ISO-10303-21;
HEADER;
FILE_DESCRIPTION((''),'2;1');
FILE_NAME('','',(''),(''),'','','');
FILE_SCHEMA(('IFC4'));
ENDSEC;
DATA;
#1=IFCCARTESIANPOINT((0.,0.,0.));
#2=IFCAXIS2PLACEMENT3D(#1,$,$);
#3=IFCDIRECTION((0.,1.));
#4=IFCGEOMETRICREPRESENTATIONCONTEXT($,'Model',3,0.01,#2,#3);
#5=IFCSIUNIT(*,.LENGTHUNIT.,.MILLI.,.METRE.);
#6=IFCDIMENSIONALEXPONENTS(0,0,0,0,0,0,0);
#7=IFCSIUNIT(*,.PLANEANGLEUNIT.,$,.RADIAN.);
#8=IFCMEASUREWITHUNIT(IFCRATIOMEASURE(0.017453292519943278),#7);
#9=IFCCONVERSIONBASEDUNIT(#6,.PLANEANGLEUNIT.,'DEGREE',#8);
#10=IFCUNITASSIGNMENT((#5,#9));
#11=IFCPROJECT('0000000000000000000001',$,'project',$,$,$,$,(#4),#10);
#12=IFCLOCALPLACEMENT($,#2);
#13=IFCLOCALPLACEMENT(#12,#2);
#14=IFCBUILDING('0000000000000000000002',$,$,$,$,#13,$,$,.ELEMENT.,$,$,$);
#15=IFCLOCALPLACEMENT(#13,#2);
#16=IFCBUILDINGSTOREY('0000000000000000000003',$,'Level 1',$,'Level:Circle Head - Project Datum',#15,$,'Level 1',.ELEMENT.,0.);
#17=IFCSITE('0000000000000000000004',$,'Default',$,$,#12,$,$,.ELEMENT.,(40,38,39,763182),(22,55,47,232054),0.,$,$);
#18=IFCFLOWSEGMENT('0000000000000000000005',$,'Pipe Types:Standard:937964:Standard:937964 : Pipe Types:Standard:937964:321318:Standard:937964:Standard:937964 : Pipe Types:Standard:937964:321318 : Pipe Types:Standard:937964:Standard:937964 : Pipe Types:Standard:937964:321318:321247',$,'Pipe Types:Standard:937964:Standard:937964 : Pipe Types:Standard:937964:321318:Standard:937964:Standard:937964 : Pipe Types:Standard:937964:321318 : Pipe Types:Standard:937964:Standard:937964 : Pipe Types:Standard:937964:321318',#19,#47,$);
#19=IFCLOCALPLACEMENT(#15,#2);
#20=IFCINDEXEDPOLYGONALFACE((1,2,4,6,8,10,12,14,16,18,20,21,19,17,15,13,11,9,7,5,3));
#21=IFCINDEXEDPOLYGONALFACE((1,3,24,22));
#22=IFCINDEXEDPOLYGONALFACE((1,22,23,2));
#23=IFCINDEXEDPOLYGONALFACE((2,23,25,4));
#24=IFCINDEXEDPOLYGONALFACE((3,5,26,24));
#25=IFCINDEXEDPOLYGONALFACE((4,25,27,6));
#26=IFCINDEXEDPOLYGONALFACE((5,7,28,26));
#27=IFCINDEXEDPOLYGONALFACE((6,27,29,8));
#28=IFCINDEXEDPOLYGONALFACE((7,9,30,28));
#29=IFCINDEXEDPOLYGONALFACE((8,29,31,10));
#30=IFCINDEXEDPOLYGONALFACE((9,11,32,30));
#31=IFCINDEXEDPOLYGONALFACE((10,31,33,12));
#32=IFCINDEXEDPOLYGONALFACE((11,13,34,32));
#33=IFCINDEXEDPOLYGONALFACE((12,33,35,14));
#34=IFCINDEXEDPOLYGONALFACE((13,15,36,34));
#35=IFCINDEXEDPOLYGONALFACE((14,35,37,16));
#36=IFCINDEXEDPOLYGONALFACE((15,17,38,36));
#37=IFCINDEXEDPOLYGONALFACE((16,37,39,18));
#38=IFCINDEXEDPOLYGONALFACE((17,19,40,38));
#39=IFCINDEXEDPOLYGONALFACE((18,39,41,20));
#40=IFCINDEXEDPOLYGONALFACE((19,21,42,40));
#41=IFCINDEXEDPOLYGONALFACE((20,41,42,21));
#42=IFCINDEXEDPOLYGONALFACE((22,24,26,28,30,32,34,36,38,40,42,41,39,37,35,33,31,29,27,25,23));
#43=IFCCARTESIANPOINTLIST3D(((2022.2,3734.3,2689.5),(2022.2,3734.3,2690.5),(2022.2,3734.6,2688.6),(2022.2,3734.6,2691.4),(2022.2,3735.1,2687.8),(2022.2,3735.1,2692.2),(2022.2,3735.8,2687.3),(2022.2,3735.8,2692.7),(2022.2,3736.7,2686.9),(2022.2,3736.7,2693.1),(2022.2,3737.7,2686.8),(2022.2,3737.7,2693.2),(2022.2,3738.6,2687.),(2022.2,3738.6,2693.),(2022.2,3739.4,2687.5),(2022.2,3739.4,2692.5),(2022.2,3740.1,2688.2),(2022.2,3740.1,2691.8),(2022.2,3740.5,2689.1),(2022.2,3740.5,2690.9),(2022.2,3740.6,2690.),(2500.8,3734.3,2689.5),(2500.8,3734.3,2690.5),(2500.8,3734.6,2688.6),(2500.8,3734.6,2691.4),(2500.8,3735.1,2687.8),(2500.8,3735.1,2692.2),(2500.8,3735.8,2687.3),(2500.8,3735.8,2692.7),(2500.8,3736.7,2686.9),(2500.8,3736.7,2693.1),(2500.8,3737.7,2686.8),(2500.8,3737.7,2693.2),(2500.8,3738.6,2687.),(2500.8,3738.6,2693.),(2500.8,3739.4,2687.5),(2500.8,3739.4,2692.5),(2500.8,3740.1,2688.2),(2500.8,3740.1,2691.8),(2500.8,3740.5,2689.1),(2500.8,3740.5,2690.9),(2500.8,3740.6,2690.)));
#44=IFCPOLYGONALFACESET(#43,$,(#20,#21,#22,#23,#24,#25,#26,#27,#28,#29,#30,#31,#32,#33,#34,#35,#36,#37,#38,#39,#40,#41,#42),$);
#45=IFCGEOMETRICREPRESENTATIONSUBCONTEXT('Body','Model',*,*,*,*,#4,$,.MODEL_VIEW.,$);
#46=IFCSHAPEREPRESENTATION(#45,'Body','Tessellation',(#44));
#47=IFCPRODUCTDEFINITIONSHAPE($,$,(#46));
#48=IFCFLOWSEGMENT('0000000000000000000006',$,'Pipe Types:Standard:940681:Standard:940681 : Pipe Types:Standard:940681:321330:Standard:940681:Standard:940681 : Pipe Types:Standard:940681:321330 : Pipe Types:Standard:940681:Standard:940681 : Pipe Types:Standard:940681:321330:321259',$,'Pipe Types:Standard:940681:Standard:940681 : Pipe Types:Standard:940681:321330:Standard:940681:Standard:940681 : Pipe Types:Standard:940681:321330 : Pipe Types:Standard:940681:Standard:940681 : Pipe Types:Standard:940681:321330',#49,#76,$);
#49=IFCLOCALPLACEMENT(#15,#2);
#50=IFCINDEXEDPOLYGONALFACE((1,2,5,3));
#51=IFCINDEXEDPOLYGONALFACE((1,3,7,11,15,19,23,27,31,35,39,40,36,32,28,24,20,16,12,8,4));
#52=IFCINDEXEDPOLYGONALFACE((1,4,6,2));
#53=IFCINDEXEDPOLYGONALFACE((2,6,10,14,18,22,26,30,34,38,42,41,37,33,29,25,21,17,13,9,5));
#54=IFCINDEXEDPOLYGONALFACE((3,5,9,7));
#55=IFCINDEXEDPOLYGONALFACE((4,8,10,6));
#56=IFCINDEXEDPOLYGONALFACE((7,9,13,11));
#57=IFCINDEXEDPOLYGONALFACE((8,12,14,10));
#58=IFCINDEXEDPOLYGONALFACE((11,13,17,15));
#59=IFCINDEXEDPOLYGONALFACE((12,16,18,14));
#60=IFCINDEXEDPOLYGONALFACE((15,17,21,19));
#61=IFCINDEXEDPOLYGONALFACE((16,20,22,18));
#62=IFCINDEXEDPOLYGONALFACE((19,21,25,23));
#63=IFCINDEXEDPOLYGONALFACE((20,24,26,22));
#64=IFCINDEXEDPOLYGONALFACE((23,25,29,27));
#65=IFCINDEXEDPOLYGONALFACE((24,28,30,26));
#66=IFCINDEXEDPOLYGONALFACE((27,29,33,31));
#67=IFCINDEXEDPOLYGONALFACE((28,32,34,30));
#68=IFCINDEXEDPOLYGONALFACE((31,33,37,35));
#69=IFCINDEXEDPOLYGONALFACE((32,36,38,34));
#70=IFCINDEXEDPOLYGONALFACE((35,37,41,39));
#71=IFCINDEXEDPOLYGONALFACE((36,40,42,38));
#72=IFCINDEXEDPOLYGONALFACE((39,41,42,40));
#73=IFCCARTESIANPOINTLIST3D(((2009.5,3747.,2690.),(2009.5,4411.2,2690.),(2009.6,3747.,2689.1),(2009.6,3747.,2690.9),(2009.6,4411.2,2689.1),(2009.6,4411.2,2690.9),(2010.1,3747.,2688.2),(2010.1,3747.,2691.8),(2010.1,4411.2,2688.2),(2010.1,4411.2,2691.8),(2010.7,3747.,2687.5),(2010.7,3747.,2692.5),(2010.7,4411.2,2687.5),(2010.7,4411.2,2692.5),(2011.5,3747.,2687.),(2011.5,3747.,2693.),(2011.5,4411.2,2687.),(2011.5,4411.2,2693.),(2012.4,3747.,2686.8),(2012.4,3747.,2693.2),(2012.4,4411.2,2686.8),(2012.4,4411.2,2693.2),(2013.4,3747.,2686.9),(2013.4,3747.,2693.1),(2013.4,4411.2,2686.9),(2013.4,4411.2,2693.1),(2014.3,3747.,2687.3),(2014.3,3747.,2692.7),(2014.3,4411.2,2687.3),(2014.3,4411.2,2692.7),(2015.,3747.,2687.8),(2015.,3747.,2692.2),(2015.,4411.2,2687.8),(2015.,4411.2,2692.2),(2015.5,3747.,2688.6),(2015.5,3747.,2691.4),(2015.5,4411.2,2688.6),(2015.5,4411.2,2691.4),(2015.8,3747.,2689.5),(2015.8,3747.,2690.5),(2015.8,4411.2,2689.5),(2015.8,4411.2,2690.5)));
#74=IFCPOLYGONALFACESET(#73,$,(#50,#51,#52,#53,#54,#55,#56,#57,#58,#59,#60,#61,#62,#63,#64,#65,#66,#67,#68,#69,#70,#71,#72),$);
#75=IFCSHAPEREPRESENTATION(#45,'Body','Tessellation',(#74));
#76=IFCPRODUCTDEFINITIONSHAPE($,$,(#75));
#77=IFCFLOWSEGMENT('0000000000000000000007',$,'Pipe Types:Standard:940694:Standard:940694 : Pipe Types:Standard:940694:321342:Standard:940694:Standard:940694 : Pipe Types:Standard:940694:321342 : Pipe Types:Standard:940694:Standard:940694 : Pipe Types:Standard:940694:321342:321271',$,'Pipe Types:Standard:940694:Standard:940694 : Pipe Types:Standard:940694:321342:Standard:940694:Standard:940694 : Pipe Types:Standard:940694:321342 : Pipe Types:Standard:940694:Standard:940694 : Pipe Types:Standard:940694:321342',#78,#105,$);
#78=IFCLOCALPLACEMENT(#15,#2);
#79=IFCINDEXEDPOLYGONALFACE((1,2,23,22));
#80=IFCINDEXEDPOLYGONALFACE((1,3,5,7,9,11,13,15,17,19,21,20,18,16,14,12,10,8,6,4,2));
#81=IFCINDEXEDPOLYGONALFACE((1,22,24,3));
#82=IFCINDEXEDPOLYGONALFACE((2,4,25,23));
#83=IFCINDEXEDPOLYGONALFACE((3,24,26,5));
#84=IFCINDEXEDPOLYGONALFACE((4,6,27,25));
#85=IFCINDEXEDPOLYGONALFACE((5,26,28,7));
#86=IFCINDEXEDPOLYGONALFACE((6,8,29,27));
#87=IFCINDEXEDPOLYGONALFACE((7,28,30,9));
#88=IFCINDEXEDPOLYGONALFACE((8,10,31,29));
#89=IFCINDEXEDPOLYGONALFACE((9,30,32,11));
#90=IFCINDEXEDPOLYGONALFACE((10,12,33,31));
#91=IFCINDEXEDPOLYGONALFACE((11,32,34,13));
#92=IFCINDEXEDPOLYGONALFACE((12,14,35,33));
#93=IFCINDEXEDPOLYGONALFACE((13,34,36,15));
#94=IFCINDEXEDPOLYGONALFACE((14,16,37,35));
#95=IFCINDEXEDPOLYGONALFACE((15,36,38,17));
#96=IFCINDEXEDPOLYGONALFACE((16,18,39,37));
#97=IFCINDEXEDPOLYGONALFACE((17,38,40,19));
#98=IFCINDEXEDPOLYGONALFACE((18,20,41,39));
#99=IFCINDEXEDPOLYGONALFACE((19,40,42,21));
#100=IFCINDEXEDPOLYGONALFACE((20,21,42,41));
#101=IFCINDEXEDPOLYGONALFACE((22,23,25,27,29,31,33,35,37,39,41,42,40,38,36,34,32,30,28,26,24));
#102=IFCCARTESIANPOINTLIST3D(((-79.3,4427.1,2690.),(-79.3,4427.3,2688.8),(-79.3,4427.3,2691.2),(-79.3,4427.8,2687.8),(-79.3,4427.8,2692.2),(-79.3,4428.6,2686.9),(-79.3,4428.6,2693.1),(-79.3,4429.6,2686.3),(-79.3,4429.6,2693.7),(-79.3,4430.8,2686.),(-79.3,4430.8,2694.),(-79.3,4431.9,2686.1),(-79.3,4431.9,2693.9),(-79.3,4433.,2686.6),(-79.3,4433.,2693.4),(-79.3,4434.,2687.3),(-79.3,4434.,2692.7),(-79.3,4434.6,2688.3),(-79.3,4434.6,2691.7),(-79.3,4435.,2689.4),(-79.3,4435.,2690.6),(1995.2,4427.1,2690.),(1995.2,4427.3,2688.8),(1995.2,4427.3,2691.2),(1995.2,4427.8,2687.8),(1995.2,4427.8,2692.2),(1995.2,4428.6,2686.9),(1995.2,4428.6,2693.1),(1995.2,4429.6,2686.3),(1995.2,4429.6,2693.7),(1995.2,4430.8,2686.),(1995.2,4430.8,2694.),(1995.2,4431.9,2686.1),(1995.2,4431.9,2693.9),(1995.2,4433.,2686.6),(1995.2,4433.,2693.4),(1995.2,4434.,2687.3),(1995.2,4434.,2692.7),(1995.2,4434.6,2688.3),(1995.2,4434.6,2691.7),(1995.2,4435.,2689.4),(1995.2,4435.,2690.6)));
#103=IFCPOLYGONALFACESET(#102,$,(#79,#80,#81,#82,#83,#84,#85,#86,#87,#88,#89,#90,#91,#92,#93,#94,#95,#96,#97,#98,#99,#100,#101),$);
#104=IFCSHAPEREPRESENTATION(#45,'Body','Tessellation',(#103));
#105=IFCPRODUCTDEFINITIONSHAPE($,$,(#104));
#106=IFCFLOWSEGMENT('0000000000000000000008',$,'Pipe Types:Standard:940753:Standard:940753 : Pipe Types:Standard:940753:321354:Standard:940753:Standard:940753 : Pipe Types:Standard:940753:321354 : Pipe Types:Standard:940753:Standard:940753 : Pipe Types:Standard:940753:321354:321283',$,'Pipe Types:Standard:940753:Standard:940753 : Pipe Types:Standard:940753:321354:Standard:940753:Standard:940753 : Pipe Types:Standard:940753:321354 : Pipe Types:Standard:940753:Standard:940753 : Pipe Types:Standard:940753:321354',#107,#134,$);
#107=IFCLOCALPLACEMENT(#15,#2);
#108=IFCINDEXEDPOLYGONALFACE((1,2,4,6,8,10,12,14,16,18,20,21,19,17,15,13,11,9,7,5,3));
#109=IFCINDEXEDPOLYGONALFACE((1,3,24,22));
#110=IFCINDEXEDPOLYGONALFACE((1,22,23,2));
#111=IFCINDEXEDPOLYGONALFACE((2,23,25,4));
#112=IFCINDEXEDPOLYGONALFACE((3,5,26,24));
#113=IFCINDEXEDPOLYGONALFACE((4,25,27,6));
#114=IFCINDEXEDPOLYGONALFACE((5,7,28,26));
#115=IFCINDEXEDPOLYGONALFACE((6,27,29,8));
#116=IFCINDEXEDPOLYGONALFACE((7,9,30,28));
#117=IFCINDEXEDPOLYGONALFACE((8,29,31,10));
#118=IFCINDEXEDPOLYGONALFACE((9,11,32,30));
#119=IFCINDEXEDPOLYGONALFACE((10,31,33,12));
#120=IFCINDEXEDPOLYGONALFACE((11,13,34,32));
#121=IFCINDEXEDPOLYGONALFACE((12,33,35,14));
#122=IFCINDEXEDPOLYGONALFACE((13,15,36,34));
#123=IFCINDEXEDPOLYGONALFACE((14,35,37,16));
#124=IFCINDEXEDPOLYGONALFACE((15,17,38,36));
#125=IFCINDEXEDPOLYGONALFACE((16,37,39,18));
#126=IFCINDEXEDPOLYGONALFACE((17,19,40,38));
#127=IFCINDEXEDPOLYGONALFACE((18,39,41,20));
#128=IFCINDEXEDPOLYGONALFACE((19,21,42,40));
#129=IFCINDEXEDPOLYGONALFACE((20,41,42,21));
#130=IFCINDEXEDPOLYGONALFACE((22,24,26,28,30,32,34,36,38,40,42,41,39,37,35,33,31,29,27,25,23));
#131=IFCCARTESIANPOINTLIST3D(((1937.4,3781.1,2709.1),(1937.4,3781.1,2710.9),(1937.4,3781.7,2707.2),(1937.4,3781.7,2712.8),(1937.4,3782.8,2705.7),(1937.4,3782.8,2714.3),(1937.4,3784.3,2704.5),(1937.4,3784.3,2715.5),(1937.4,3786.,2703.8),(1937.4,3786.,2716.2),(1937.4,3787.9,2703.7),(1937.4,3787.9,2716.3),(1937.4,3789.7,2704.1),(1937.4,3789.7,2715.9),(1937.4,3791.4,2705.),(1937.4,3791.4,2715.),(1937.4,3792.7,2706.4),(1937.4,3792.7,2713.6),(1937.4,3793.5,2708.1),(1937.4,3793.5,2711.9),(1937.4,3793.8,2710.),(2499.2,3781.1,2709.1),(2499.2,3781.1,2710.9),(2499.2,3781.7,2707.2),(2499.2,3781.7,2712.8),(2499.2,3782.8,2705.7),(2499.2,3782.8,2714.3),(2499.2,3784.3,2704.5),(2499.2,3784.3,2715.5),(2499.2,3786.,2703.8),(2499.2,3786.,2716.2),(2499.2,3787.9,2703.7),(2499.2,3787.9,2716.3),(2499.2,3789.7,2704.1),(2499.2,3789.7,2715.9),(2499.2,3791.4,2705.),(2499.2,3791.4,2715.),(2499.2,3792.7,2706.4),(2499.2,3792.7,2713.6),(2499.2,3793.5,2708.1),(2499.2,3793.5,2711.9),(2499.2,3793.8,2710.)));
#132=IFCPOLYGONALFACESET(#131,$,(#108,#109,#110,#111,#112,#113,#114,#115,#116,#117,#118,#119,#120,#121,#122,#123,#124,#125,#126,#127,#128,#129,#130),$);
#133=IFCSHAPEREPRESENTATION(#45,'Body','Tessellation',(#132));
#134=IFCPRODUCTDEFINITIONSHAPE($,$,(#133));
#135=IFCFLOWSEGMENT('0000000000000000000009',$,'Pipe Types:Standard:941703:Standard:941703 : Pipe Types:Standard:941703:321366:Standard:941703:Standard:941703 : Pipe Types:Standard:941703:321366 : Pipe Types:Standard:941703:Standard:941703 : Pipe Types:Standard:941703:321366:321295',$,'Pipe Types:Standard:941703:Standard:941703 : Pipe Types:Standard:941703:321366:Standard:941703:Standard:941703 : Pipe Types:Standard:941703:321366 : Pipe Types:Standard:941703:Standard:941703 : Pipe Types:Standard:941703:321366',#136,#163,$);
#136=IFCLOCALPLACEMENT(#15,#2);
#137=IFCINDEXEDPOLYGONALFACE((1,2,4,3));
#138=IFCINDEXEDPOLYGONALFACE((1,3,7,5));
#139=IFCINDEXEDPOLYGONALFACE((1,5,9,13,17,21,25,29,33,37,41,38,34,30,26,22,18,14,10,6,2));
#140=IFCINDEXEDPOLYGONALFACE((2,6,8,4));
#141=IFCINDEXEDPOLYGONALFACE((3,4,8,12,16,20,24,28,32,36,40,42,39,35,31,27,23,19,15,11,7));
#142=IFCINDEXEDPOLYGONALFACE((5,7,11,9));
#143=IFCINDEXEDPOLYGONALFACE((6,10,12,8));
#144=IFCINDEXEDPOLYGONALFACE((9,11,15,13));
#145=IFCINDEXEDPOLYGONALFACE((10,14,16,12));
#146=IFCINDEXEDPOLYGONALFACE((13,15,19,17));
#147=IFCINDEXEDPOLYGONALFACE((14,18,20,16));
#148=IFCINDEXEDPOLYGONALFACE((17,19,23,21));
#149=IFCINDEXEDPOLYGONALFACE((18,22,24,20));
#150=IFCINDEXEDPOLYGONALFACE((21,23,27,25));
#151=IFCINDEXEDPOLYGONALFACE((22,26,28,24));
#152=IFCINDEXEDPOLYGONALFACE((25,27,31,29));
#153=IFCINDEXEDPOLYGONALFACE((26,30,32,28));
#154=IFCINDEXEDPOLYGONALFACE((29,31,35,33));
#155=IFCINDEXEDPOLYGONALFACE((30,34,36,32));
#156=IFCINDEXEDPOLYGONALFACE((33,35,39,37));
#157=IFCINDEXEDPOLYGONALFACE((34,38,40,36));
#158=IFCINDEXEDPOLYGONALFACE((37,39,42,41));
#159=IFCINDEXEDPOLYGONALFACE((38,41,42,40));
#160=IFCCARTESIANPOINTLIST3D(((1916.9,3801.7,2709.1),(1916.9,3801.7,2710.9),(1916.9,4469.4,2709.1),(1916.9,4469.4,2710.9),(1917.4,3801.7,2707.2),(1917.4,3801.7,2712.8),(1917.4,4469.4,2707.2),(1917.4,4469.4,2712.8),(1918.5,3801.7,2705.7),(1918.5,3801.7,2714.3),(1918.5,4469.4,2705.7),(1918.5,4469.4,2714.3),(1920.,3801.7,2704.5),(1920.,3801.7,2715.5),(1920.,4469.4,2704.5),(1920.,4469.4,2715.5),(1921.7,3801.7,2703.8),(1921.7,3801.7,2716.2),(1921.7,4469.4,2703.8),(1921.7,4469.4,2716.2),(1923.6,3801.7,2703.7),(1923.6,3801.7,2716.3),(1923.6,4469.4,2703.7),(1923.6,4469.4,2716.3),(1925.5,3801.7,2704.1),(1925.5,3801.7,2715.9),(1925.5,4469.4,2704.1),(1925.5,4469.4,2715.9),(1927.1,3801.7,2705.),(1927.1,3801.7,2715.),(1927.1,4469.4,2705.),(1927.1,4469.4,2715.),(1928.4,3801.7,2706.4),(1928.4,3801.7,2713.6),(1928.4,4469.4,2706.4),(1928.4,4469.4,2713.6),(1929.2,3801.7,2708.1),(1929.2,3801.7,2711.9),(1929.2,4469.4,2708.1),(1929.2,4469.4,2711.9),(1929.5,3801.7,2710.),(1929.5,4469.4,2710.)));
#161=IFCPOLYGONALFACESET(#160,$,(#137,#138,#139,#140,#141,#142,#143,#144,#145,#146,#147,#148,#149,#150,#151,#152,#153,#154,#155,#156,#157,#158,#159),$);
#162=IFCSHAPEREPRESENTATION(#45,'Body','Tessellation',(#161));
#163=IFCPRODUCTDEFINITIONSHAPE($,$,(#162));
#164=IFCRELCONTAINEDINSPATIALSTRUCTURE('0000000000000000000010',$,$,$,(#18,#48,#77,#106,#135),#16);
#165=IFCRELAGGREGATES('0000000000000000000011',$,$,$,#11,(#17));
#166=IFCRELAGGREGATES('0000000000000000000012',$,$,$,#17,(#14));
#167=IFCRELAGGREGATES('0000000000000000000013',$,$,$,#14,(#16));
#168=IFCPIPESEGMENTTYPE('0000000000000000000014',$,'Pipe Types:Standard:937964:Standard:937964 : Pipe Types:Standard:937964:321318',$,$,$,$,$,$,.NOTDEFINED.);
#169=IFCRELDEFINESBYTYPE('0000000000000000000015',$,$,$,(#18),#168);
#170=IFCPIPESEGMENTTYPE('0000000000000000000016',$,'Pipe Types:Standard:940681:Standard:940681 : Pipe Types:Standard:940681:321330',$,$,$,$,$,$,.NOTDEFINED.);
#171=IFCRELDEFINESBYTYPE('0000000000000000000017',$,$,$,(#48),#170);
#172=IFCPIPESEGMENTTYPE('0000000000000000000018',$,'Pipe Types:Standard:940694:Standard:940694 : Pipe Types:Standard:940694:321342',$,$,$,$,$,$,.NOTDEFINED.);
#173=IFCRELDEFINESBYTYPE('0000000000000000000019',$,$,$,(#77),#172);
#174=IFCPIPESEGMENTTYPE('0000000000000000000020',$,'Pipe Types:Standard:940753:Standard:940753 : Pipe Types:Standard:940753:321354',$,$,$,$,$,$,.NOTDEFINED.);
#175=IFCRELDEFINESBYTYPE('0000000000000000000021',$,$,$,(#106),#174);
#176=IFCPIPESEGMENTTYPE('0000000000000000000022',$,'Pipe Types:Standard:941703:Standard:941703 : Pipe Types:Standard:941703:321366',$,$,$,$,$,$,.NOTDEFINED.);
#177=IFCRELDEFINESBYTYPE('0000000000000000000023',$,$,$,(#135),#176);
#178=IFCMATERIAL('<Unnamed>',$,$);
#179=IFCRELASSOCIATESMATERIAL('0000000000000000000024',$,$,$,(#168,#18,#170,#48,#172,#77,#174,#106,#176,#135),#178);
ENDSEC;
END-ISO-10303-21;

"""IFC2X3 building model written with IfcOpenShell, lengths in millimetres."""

from ifc_helpers import new_model, entity, si_unit, converted_unit, direction, frame, origin, origin_2d_with_axis, place, context, subcontext, project, spatial, circle, extrude, source, transform, mapped, material, type_object, type_shapes, element, save


model = new_model("IFC2X3")

# Units and contexts
model_context = context("Model", 3, precision=0.01, world=origin(), true_north=direction((0.0, 1.0)))
body_context = subcontext(model_context, "Body", "Model", "MODEL_VIEW")
ifc_project = project(units=[si_unit("LENGTHUNIT", "METRE", prefix="MILLI"), converted_unit("PLANEANGLEUNIT", "DEGREE", entity("IfcRatioMeasure", 0.017453292519943278), si_unit("PLANEANGLEUNIT", "RADIAN"), dimensions=[0, 0, 0, 0, 0, 0, 0])], contexts=[model_context])

# Site, building, storey
site_placement = place(None, origin())
site = spatial("IfcSite", under=ifc_project, at=site_placement, Name="Default", CompositionType="ELEMENT", RefLatitude=(40, 38, 39, 763182), RefLongitude=(22, 55, 47, 232054), RefElevation=0.0)
building_placement = place(site_placement, origin())
building = spatial("IfcBuilding", under=site, at=building_placement, CompositionType="ELEMENT")
storey_placement = place(building_placement, origin())
storey = spatial("IfcBuildingStorey", under=building, at=storey_placement, Name="Level 1", ObjectType="Level:Circle Head - Project Datum", LongName="Level 1", CompositionType="ELEMENT", Elevation=0.0)

# Flow segments
ifc_material_1 = material(Name="<Unnamed>")
pipe_segment_type_1 = type_object("IfcPipeSegmentType", Name="Pipe Types:Standard:937964:Standard:937964 : Pipe Types:Standard:937964:321318", PredefinedType="NOTDEFINED", material=ifc_material_1)
shared_shape_1 = source(origin(), body_context, "Body", "SweptSolid", [
    extrude(circle(Radius=3.2, at=origin_2d_with_axis()), frame((2022.2, 3737.4, 2690.0), z_axis=(1.0, 0.0, 0.0), x_axis=(0.0, 1.0, 0.0)), (0.0, 0.0, 1.0), 478.6),
])
type_shapes(pipe_segment_type_1, [shared_shape_1])
flow_segment_1_placement = place(storey_placement, origin())
element("IfcFlowSegment", 1, at=flow_segment_1_placement, inside=storey, type_object=pipe_segment_type_1, material=ifc_material_1, Name="Pipe Types:Standard:937964:Standard:937964 : Pipe Types:Standard:937964:321318:Standard:937964:Standard:937964 : Pipe Types:Standard:937964:321318 : Pipe Types:Standard:937964:Standard:937964 : Pipe Types:Standard:937964:321318:321247", ObjectType="Pipe Types:Standard:937964:Standard:937964 : Pipe Types:Standard:937964:321318:Standard:937964:Standard:937964 : Pipe Types:Standard:937964:321318 : Pipe Types:Standard:937964:Standard:937964 : Pipe Types:Standard:937964:321318", context=body_context, shape_type="MappedRepresentation", body=[
    mapped(shared_shape_1, transform((0.0, 0.0, 0.0), scale=1.0)),
])
pipe_segment_type_2 = type_object("IfcPipeSegmentType", Name="Pipe Types:Standard:940681:Standard:940681 : Pipe Types:Standard:940681:321330", PredefinedType="NOTDEFINED", material=ifc_material_1)
shared_shape_2 = source(origin(), body_context, "Body", "SweptSolid", [
    extrude(circle(Radius=3.2, at=origin_2d_with_axis()), frame((2012.7, 3747.0, 2690.0), z_axis=(0.0, 1.0, 0.0), x_axis=(-1.0, 0.0, 0.0)), (0.0, 0.0, 1.0), 664.3),
])
type_shapes(pipe_segment_type_2, [shared_shape_2])
flow_segment_2_placement = place(storey_placement, origin())
element("IfcFlowSegment", 2, at=flow_segment_2_placement, inside=storey, type_object=pipe_segment_type_2, material=ifc_material_1, Name="Pipe Types:Standard:940681:Standard:940681 : Pipe Types:Standard:940681:321330:Standard:940681:Standard:940681 : Pipe Types:Standard:940681:321330 : Pipe Types:Standard:940681:Standard:940681 : Pipe Types:Standard:940681:321330:321259", ObjectType="Pipe Types:Standard:940681:Standard:940681 : Pipe Types:Standard:940681:321330:Standard:940681:Standard:940681 : Pipe Types:Standard:940681:321330 : Pipe Types:Standard:940681:Standard:940681 : Pipe Types:Standard:940681:321330", context=body_context, shape_type="MappedRepresentation", body=[
    mapped(shared_shape_2, transform((0.0, 0.0, 0.0), scale=1.0)),
])
pipe_segment_type_3 = type_object("IfcPipeSegmentType", Name="Pipe Types:Standard:940694:Standard:940694 : Pipe Types:Standard:940694:321342", PredefinedType="NOTDEFINED", material=ifc_material_1)
shared_shape_3 = source(origin(), body_context, "Body", "SweptSolid", [
    extrude(circle(Radius=4.0, at=origin_2d_with_axis()), frame((-79.3, 4431.1, 2690.0), z_axis=(1.0, 0.0, 0.0), x_axis=(0.0, -1.0, 0.0)), (0.0, 0.0, 1.0), 2074.5),
])
type_shapes(pipe_segment_type_3, [shared_shape_3])
flow_segment_3_placement = place(storey_placement, origin())
element("IfcFlowSegment", 3, at=flow_segment_3_placement, inside=storey, type_object=pipe_segment_type_3, material=ifc_material_1, Name="Pipe Types:Standard:940694:Standard:940694 : Pipe Types:Standard:940694:321342:Standard:940694:Standard:940694 : Pipe Types:Standard:940694:321342 : Pipe Types:Standard:940694:Standard:940694 : Pipe Types:Standard:940694:321342:321271", ObjectType="Pipe Types:Standard:940694:Standard:940694 : Pipe Types:Standard:940694:321342:Standard:940694:Standard:940694 : Pipe Types:Standard:940694:321342 : Pipe Types:Standard:940694:Standard:940694 : Pipe Types:Standard:940694:321342", context=body_context, shape_type="MappedRepresentation", body=[
    mapped(shared_shape_3, transform((0.0, 0.0, 0.0), scale=1.0)),
])
pipe_segment_type_4 = type_object("IfcPipeSegmentType", Name="Pipe Types:Standard:940753:Standard:940753 : Pipe Types:Standard:940753:321354", PredefinedType="NOTDEFINED", material=ifc_material_1)
shared_shape_4 = source(origin(), body_context, "Body", "SweptSolid", [
    extrude(circle(Radius=6.3, at=origin_2d_with_axis()), frame((1937.4, 3787.4, 2710.0), z_axis=(1.0, 0.0, 0.0), x_axis=(0.0, 1.0, 0.0)), (0.0, 0.0, 1.0), 561.7),
])
type_shapes(pipe_segment_type_4, [shared_shape_4])
flow_segment_4_placement = place(storey_placement, origin())
element("IfcFlowSegment", 4, at=flow_segment_4_placement, inside=storey, type_object=pipe_segment_type_4, material=ifc_material_1, Name="Pipe Types:Standard:940753:Standard:940753 : Pipe Types:Standard:940753:321354:Standard:940753:Standard:940753 : Pipe Types:Standard:940753:321354 : Pipe Types:Standard:940753:Standard:940753 : Pipe Types:Standard:940753:321354:321283", ObjectType="Pipe Types:Standard:940753:Standard:940753 : Pipe Types:Standard:940753:321354:Standard:940753:Standard:940753 : Pipe Types:Standard:940753:321354 : Pipe Types:Standard:940753:Standard:940753 : Pipe Types:Standard:940753:321354", context=body_context, shape_type="MappedRepresentation", body=[
    mapped(shared_shape_4, transform((0.0, 0.0, 0.0), scale=1.0)),
])
pipe_segment_type_5 = type_object("IfcPipeSegmentType", Name="Pipe Types:Standard:941703:Standard:941703 : Pipe Types:Standard:941703:321366", PredefinedType="NOTDEFINED", material=ifc_material_1)
shared_shape_5 = source(origin(), body_context, "Body", "SweptSolid", [
    extrude(circle(Radius=6.3, at=origin_2d_with_axis()), frame((1923.2, 3801.7, 2710.0), z_axis=(0.0, 1.0, 0.0), x_axis=(1.0, 0.0, 0.0)), (0.0, 0.0, 1.0), 667.7),
])
type_shapes(pipe_segment_type_5, [shared_shape_5])
flow_segment_5_placement = place(storey_placement, origin())
element("IfcFlowSegment", 5, at=flow_segment_5_placement, inside=storey, type_object=pipe_segment_type_5, material=ifc_material_1, Name="Pipe Types:Standard:941703:Standard:941703 : Pipe Types:Standard:941703:321366:Standard:941703:Standard:941703 : Pipe Types:Standard:941703:321366 : Pipe Types:Standard:941703:Standard:941703 : Pipe Types:Standard:941703:321366:321295", ObjectType="Pipe Types:Standard:941703:Standard:941703 : Pipe Types:Standard:941703:321366:Standard:941703:Standard:941703 : Pipe Types:Standard:941703:321366 : Pipe Types:Standard:941703:Standard:941703 : Pipe Types:Standard:941703:321366", context=body_context, shape_type="MappedRepresentation", body=[
    mapped(shared_shape_5, transform((0.0, 0.0, 0.0), scale=1.0)),
])

save(model, "model.ifc")
